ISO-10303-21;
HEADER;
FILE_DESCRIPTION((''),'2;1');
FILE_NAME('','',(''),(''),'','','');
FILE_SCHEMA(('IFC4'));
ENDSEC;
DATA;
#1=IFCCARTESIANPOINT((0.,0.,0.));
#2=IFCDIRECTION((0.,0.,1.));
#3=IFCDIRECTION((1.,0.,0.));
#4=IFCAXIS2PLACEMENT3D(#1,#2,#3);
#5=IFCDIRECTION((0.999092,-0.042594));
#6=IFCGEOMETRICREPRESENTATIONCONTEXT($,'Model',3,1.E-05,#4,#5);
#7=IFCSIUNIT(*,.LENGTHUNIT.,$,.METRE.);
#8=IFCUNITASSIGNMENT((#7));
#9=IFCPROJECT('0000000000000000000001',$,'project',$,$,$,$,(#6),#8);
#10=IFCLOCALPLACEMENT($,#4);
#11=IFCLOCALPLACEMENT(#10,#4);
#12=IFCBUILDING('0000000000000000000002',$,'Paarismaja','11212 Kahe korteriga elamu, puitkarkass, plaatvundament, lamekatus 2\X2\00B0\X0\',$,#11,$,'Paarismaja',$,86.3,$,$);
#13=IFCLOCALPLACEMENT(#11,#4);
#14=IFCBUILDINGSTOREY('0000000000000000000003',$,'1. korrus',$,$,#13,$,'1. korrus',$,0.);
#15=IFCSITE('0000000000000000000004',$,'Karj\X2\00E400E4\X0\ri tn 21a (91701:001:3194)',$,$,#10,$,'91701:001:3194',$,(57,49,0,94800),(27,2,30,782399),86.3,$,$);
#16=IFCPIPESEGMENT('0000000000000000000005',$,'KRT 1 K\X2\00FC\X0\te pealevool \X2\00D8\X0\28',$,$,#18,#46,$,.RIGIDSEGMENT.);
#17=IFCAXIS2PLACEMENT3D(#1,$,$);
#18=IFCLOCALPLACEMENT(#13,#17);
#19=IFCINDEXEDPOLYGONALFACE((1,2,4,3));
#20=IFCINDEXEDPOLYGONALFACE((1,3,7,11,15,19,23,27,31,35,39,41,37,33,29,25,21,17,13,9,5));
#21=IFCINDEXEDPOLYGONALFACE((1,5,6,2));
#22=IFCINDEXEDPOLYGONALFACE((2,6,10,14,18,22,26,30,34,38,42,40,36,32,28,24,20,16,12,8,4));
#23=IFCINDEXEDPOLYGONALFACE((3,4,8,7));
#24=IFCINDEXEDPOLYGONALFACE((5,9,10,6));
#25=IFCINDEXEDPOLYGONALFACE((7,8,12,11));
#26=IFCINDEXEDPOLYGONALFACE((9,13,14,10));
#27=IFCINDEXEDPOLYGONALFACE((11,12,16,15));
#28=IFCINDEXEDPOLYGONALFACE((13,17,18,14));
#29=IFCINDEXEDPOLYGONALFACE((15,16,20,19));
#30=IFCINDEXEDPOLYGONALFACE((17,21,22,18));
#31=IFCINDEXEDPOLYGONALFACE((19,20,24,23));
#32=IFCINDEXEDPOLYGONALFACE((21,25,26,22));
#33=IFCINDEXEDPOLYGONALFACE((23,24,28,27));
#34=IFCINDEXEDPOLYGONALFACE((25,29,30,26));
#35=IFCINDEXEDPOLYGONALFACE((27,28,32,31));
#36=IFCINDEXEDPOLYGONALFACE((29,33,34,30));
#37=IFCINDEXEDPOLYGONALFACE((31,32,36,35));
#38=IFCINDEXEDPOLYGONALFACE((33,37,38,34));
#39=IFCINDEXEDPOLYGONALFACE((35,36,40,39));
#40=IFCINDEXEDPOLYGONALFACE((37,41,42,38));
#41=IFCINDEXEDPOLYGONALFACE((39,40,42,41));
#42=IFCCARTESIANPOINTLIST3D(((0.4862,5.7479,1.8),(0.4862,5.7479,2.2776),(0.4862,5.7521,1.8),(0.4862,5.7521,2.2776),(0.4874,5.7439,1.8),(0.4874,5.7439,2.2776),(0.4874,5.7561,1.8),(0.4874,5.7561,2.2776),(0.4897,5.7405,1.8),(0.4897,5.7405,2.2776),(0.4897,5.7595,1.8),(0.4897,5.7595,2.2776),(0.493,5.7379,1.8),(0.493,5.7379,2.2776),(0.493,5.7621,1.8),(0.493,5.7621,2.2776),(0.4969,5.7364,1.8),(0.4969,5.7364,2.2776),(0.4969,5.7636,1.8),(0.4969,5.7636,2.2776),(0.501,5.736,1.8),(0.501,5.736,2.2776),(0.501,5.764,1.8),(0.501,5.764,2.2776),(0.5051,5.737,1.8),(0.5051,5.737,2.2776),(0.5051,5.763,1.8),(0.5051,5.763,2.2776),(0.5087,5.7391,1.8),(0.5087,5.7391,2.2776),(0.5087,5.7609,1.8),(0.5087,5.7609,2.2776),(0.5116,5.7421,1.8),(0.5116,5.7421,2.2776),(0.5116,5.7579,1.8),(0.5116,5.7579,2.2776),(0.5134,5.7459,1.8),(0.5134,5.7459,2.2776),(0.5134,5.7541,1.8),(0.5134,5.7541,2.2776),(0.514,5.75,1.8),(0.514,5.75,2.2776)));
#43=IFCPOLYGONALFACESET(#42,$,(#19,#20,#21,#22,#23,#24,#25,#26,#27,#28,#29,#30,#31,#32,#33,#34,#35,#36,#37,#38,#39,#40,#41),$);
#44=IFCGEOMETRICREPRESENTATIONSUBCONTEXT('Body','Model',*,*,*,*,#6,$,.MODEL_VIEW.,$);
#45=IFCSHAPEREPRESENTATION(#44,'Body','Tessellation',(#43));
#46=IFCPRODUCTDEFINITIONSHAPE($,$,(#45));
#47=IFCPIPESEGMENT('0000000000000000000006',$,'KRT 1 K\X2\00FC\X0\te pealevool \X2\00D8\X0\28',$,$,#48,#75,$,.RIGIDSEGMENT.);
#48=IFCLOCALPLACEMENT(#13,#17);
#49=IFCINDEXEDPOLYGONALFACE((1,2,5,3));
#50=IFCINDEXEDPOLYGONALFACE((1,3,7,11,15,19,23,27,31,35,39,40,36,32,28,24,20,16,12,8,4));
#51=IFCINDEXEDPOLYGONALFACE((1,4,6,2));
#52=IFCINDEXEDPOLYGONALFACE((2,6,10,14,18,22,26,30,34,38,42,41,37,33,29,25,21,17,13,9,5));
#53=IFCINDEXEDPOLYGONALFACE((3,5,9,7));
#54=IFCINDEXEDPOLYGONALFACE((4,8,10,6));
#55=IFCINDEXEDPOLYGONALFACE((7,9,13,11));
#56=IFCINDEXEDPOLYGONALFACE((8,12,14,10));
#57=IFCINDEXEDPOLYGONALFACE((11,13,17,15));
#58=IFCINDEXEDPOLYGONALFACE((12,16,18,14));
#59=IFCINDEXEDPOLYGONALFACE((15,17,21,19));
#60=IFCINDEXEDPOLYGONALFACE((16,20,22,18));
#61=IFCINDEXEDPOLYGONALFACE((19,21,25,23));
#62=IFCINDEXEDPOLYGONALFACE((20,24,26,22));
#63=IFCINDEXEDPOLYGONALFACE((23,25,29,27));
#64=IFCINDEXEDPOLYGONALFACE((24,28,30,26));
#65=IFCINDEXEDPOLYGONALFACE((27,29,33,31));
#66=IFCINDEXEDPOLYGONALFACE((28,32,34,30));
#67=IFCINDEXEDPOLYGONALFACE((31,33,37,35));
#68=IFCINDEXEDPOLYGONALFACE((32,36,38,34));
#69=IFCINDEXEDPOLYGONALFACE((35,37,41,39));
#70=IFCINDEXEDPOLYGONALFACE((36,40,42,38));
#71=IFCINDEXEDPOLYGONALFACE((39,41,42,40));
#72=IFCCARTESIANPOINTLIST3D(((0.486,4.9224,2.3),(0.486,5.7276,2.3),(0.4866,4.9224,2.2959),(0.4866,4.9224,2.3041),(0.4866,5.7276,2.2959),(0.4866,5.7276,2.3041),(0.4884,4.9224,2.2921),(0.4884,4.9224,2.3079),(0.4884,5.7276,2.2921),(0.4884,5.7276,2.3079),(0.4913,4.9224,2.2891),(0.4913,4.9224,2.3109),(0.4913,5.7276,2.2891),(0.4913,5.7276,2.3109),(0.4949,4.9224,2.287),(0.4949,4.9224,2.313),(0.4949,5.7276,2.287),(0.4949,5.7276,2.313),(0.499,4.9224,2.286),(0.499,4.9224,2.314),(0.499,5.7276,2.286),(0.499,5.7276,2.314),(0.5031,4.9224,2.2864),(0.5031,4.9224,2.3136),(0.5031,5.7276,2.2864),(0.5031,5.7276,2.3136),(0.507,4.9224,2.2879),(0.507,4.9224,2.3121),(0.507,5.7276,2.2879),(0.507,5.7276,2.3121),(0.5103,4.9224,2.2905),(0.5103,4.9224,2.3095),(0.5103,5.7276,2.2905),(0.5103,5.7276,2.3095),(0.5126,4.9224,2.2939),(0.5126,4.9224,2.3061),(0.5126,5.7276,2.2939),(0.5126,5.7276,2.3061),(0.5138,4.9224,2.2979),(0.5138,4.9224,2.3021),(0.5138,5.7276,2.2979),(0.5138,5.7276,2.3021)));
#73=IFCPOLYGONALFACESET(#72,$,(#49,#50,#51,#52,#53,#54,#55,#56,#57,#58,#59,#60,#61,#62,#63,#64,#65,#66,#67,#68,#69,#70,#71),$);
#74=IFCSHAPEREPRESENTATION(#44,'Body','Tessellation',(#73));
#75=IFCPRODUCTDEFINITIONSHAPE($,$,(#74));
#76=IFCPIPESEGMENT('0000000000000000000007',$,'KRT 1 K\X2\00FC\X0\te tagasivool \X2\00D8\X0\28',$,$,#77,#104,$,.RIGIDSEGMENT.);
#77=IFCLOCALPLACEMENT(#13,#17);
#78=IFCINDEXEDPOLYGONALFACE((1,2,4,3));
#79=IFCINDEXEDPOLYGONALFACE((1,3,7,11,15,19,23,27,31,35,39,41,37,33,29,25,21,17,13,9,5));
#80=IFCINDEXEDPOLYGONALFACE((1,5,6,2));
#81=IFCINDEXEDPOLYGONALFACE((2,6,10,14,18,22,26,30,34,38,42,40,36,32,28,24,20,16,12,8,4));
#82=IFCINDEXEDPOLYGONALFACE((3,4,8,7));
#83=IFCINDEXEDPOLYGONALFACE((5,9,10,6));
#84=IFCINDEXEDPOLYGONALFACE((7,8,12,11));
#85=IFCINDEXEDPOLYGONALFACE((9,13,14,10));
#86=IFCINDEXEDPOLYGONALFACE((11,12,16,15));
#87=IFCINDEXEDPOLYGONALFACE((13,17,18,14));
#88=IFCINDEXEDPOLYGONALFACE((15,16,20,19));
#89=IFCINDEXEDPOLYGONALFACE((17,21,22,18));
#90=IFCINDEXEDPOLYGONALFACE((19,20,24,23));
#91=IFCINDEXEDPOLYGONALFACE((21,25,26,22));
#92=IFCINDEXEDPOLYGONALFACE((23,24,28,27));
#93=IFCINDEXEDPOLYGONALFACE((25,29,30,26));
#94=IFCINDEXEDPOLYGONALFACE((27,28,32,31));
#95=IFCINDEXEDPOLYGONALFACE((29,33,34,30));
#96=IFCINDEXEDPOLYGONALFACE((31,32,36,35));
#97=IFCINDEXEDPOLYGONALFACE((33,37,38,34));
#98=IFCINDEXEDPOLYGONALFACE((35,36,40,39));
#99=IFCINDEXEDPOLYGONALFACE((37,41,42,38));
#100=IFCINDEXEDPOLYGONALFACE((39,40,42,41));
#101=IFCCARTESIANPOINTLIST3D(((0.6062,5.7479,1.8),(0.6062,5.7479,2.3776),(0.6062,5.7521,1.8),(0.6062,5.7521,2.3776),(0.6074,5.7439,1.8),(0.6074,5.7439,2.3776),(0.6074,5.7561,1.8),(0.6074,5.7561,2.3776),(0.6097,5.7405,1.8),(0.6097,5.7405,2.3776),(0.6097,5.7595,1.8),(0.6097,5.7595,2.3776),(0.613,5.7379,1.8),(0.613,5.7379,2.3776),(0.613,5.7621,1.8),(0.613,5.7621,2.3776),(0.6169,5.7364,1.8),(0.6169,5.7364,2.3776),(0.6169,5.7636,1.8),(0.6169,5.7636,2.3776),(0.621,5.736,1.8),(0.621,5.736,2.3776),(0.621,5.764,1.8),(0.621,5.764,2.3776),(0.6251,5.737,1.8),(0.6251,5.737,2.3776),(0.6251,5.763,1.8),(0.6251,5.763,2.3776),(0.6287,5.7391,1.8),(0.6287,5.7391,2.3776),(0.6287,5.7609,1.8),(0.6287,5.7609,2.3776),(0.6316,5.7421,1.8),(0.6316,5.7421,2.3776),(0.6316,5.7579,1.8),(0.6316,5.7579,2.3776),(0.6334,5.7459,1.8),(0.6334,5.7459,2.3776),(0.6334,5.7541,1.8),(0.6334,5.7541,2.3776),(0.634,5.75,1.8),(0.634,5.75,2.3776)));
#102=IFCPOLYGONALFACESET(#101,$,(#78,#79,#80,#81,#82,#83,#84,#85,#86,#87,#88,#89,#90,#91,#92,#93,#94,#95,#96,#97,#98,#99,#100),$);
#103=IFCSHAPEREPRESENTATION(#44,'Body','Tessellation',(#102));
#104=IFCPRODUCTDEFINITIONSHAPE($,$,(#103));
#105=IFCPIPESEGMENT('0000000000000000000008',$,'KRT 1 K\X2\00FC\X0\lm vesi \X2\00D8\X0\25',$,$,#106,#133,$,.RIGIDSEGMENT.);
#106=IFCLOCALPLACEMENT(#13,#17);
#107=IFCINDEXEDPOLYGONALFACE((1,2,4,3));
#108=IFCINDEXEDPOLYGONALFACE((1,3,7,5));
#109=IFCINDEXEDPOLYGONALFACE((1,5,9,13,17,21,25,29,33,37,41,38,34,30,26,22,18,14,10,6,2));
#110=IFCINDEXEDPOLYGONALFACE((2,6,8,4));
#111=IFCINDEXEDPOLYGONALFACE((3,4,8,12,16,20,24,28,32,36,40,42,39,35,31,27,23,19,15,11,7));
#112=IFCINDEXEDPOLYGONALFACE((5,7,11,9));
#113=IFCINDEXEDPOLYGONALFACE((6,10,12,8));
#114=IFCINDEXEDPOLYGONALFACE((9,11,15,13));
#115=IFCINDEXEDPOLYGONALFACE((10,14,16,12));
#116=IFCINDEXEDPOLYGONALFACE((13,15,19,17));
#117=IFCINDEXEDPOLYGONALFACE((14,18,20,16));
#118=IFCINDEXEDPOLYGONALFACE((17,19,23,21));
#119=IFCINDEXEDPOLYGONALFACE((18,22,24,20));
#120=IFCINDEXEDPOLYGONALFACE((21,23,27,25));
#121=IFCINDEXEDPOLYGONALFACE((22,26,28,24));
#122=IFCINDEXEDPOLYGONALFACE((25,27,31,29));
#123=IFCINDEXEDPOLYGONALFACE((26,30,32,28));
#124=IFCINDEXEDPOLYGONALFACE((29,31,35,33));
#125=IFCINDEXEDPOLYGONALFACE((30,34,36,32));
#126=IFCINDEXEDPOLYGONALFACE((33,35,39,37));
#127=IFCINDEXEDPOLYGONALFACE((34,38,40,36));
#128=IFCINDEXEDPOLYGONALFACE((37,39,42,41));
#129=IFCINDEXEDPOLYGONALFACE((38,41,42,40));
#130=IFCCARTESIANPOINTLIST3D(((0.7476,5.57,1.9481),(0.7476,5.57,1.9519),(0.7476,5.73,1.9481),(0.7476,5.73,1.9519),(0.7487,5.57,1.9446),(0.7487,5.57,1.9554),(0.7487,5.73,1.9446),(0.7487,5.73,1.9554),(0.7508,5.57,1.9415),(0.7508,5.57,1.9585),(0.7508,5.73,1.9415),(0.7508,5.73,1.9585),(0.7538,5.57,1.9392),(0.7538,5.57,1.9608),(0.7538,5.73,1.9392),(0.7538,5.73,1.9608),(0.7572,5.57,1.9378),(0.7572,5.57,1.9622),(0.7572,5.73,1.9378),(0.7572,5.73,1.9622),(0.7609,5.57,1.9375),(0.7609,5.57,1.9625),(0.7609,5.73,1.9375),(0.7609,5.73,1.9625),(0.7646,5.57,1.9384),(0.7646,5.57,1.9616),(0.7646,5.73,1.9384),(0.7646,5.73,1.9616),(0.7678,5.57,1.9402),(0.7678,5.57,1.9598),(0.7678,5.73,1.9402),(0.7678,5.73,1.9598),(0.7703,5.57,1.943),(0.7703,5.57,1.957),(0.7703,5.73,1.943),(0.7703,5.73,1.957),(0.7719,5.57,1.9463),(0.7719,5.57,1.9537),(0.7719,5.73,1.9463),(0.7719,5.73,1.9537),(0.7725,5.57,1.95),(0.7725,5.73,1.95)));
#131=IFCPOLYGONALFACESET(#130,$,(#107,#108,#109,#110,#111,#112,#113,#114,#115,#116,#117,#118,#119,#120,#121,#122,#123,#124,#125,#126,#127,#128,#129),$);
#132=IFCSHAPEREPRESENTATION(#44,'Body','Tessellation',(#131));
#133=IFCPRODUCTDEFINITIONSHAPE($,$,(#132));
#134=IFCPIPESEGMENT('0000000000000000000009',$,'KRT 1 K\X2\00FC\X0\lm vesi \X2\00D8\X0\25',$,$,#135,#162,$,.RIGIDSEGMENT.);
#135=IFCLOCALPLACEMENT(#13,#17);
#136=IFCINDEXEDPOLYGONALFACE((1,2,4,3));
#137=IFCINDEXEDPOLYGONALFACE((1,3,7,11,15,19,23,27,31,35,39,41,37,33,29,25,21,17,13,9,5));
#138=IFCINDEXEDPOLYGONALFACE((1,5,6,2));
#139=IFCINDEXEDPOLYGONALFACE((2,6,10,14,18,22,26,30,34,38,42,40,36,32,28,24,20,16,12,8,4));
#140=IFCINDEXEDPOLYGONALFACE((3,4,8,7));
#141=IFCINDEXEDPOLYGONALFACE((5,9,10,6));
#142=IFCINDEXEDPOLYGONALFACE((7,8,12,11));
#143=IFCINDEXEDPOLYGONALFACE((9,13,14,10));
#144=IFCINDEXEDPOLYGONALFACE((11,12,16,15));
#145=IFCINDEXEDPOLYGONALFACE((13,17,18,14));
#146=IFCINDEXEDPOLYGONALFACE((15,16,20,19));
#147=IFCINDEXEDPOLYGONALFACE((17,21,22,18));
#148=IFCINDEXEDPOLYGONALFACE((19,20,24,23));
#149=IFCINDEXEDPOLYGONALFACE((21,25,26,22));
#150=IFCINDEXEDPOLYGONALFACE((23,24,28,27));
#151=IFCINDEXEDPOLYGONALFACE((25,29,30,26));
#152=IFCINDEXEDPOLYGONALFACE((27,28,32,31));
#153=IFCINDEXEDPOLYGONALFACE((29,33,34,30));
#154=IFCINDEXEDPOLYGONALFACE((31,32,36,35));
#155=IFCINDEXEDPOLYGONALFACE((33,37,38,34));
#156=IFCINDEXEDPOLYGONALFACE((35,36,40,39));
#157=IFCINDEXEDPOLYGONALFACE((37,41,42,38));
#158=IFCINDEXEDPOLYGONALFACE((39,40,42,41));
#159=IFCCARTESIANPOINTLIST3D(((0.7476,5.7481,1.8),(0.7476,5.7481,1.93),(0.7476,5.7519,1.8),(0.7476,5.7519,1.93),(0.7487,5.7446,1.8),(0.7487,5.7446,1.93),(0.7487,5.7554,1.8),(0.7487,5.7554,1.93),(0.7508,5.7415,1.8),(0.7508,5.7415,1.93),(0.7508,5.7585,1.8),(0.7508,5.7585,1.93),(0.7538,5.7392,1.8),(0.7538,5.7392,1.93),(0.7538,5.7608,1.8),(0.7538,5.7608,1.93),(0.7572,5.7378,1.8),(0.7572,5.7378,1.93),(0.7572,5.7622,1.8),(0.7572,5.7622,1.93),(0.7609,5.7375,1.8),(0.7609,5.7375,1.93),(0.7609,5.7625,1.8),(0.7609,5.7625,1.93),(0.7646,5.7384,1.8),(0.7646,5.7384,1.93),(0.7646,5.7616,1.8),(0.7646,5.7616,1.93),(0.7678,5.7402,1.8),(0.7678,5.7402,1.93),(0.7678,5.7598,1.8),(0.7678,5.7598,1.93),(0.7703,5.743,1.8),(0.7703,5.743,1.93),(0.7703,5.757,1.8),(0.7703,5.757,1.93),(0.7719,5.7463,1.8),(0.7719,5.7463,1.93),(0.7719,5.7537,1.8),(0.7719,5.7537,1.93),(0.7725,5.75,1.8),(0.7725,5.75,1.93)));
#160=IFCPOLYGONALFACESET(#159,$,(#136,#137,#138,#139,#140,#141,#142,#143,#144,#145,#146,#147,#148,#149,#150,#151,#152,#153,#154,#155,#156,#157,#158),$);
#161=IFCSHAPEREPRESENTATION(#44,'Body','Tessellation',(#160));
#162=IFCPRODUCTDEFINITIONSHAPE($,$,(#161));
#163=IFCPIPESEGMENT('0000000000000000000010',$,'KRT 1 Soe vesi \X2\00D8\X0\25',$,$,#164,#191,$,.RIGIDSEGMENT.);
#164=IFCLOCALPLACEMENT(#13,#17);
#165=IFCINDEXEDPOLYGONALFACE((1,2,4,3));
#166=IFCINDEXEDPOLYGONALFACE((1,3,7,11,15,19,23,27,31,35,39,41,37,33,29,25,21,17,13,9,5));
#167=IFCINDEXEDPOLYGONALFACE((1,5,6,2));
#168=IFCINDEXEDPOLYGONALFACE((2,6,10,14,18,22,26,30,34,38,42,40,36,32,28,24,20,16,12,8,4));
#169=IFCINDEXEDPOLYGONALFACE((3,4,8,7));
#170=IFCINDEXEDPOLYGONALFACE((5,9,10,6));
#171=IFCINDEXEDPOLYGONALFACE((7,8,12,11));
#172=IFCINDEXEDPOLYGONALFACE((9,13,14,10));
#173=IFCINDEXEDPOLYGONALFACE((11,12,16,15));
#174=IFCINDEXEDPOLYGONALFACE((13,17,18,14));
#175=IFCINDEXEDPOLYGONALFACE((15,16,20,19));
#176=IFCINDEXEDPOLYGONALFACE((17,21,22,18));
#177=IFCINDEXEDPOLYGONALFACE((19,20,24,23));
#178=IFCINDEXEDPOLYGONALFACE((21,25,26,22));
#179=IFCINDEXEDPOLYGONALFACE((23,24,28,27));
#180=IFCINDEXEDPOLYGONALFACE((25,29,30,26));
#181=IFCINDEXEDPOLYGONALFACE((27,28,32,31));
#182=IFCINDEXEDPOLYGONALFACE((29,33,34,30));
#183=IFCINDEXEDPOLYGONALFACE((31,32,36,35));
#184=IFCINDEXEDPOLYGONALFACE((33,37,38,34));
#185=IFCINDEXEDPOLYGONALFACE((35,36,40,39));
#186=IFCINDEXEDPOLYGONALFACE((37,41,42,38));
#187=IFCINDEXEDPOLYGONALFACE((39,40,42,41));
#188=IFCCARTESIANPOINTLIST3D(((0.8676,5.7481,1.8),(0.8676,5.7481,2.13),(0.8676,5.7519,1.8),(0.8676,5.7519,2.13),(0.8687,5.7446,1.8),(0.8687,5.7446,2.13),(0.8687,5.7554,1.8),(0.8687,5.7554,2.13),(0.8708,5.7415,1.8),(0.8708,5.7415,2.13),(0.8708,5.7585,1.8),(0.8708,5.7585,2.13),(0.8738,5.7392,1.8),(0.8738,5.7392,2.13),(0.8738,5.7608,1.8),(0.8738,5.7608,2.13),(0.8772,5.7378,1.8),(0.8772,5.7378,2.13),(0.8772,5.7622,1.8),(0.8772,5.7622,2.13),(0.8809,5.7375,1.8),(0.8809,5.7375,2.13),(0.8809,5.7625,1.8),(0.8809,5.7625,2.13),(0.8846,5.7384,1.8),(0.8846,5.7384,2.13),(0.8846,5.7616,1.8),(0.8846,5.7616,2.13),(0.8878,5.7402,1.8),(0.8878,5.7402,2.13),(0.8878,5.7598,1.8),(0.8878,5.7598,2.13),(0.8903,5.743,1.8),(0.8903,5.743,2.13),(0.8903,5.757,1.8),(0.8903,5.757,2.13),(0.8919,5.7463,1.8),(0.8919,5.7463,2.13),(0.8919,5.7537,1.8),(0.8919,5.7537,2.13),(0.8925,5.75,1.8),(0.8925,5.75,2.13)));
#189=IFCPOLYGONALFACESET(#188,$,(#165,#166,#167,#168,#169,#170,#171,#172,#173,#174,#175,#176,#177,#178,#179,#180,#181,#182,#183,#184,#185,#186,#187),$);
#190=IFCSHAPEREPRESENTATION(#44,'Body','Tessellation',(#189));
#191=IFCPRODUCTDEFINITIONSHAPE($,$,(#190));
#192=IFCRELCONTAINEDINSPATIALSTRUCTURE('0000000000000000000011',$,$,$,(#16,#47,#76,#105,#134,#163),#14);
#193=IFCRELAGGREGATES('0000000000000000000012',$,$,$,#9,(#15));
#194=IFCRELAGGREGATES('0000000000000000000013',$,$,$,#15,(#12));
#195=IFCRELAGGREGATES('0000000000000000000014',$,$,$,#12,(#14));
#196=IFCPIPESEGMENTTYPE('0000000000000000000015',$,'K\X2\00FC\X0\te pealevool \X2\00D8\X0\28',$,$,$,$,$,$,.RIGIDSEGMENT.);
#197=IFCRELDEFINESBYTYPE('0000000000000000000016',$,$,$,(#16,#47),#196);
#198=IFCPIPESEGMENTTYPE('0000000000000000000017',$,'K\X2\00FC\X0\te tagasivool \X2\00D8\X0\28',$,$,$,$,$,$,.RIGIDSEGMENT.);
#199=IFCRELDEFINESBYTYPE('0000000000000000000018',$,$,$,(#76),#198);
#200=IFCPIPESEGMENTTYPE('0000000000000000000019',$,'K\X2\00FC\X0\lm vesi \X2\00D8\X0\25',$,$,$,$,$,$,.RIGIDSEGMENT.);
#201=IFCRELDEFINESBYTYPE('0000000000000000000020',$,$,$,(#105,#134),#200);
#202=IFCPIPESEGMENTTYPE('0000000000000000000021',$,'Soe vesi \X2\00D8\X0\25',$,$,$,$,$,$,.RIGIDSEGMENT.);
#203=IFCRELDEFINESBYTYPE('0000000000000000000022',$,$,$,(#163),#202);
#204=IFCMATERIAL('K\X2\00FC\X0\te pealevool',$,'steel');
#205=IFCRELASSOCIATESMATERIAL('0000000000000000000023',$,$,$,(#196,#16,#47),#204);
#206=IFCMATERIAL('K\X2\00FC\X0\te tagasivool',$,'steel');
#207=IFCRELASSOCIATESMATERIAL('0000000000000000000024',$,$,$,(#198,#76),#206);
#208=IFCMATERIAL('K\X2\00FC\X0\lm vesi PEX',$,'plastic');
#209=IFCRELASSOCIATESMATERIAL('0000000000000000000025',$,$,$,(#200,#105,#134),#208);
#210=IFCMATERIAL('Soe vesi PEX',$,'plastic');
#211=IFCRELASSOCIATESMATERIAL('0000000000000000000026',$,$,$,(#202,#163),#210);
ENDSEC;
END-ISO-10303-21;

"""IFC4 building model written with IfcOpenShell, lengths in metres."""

from ifc_helpers import new_model, si_unit, direction, frame, origin_with_axes, place, context, subcontext, project, spatial, circle, extrude, material, type_object, element, save


model = new_model("IFC4")

# Units and contexts
model_context = context("Model", 3, precision=1e-05, world=origin_with_axes(), true_north=direction((0.999092, -0.042594)))
body_context = subcontext(model_context, "Body", "Model", "MODEL_VIEW")
ifc_project = project(units=[si_unit("LENGTHUNIT", "METRE")], contexts=[model_context])

# Site, building, storey
site_placement = place(None, origin_with_axes())
site = spatial("IfcSite", under=ifc_project, at=site_placement, Name="Karjääri tn 21a (91701:001:3194)", LongName="91701:001:3194", RefLatitude=(57, 49, 0, 94800), RefLongitude=(27, 2, 30, 782399), RefElevation=86.3)
building_placement = place(site_placement, origin_with_axes())
building = spatial("IfcBuilding", under=site, at=building_placement, Name="Paarismaja", Description="11212 Kahe korteriga elamu, puitkarkass, plaatvundament, lamekatus 2°", LongName="Paarismaja", ElevationOfRefHeight=86.3)
storey_placement = place(building_placement, origin_with_axes())
storey = spatial("IfcBuildingStorey", under=building, at=storey_placement, Name="1. korrus", LongName="1. korrus", Elevation=0.0)

# Shared definitions
ifc_material_1 = material(Name="Küte pealevool", Category="steel")
ifc_material_2 = material(Name="Küte tagasivool", Category="steel")
ifc_material_3 = material(Name="Külm vesi PEX", Category="plastic")
ifc_material_4 = material(Name="Soe vesi PEX", Category="plastic")

# Pipe segments
pipe_segment_type_1 = type_object("IfcPipeSegmentType", Name="Küte pealevool Ø28", PredefinedType="RIGIDSEGMENT", material=ifc_material_1)
pipe_segment_1_placement = place(storey_placement, frame((0.5, 5.75, 1.8), z_axis=(0.0, 0.0, 1.0), x_axis=(1.0, 0.0, 0.0)))
element("IfcPipeSegment", 1, at=pipe_segment_1_placement, inside=storey, type_object=pipe_segment_type_1, material=ifc_material_1, Name="KRT 1 Küte pealevool Ø28", PredefinedType="RIGIDSEGMENT", context=body_context, shape_type="SweptSolid", body=[
    extrude(circle(Radius=0.014), origin_with_axes(), (0.0, 0.0, 1.0), 0.4776),
])
pipe_segment_2_placement = place(storey_placement, frame((0.5, 5.7276, 2.3), z_axis=(0.0, -1.0, 0.0), x_axis=(-1.0, 0.0, 0.0)))
element("IfcPipeSegment", 2, at=pipe_segment_2_placement, inside=storey, type_object=pipe_segment_type_1, material=ifc_material_1, Name="KRT 1 Küte pealevool Ø28", PredefinedType="RIGIDSEGMENT", context=body_context, shape_type="SweptSolid", body=[
    extrude(circle(Radius=0.014), origin_with_axes(), (0.0, 0.0, 1.0), 0.8052),
])
pipe_segment_type_2 = type_object("IfcPipeSegmentType", Name="Küte tagasivool Ø28", PredefinedType="RIGIDSEGMENT", material=ifc_material_2)
pipe_segment_3_placement = place(storey_placement, frame((0.62, 5.75, 2.3776), z_axis=(0.0, 0.0, -1.0), x_axis=(1.0, 0.0, 0.0)))
element("IfcPipeSegment", 3, at=pipe_segment_3_placement, inside=storey, type_object=pipe_segment_type_2, material=ifc_material_2, Name="KRT 1 Küte tagasivool Ø28", PredefinedType="RIGIDSEGMENT", context=body_context, shape_type="SweptSolid", body=[
    extrude(circle(Radius=0.014), origin_with_axes(), (0.0, 0.0, 1.0), 0.5776),
])
pipe_segment_type_3 = type_object("IfcPipeSegmentType", Name="Külm vesi Ø25", PredefinedType="RIGIDSEGMENT", material=ifc_material_3)
pipe_segment_4_placement = place(storey_placement, frame((0.76, 5.57, 1.95), z_axis=(0.0, 1.0, 0.0), x_axis=(1.0, 0.0, 0.0)))
element("IfcPipeSegment", 4, at=pipe_segment_4_placement, inside=storey, type_object=pipe_segment_type_3, material=ifc_material_3, Name="KRT 1 Külm vesi Ø25", PredefinedType="RIGIDSEGMENT", context=body_context, shape_type="SweptSolid", body=[
    extrude(circle(Radius=0.0125), origin_with_axes(), (0.0, 0.0, 1.0), 0.16),
])
pipe_segment_5_placement = place(storey_placement, frame((0.76, 5.75, 1.93), z_axis=(0.0, 0.0, -1.0), x_axis=(1.0, 0.0, 0.0)))
element("IfcPipeSegment", 5, at=pipe_segment_5_placement, inside=storey, type_object=pipe_segment_type_3, material=ifc_material_3, Name="KRT 1 Külm vesi Ø25", PredefinedType="RIGIDSEGMENT", context=body_context, shape_type="SweptSolid", body=[
    extrude(circle(Radius=0.0125), origin_with_axes(), (0.0, 0.0, 1.0), 0.13),
])
pipe_segment_type_4 = type_object("IfcPipeSegmentType", Name="Soe vesi Ø25", PredefinedType="RIGIDSEGMENT", material=ifc_material_4)
pipe_segment_6_placement = place(storey_placement, frame((0.88, 5.75, 1.8), z_axis=(0.0, 0.0, 1.0), x_axis=(1.0, 0.0, 0.0)))
element("IfcPipeSegment", 6, at=pipe_segment_6_placement, inside=storey, type_object=pipe_segment_type_4, material=ifc_material_4, Name="KRT 1 Soe vesi Ø25", PredefinedType="RIGIDSEGMENT", context=body_context, shape_type="SweptSolid", body=[
    extrude(circle(Radius=0.0125), origin_with_axes(), (0.0, 0.0, 1.0), 0.33),
])

save(model, "model.ifc")
